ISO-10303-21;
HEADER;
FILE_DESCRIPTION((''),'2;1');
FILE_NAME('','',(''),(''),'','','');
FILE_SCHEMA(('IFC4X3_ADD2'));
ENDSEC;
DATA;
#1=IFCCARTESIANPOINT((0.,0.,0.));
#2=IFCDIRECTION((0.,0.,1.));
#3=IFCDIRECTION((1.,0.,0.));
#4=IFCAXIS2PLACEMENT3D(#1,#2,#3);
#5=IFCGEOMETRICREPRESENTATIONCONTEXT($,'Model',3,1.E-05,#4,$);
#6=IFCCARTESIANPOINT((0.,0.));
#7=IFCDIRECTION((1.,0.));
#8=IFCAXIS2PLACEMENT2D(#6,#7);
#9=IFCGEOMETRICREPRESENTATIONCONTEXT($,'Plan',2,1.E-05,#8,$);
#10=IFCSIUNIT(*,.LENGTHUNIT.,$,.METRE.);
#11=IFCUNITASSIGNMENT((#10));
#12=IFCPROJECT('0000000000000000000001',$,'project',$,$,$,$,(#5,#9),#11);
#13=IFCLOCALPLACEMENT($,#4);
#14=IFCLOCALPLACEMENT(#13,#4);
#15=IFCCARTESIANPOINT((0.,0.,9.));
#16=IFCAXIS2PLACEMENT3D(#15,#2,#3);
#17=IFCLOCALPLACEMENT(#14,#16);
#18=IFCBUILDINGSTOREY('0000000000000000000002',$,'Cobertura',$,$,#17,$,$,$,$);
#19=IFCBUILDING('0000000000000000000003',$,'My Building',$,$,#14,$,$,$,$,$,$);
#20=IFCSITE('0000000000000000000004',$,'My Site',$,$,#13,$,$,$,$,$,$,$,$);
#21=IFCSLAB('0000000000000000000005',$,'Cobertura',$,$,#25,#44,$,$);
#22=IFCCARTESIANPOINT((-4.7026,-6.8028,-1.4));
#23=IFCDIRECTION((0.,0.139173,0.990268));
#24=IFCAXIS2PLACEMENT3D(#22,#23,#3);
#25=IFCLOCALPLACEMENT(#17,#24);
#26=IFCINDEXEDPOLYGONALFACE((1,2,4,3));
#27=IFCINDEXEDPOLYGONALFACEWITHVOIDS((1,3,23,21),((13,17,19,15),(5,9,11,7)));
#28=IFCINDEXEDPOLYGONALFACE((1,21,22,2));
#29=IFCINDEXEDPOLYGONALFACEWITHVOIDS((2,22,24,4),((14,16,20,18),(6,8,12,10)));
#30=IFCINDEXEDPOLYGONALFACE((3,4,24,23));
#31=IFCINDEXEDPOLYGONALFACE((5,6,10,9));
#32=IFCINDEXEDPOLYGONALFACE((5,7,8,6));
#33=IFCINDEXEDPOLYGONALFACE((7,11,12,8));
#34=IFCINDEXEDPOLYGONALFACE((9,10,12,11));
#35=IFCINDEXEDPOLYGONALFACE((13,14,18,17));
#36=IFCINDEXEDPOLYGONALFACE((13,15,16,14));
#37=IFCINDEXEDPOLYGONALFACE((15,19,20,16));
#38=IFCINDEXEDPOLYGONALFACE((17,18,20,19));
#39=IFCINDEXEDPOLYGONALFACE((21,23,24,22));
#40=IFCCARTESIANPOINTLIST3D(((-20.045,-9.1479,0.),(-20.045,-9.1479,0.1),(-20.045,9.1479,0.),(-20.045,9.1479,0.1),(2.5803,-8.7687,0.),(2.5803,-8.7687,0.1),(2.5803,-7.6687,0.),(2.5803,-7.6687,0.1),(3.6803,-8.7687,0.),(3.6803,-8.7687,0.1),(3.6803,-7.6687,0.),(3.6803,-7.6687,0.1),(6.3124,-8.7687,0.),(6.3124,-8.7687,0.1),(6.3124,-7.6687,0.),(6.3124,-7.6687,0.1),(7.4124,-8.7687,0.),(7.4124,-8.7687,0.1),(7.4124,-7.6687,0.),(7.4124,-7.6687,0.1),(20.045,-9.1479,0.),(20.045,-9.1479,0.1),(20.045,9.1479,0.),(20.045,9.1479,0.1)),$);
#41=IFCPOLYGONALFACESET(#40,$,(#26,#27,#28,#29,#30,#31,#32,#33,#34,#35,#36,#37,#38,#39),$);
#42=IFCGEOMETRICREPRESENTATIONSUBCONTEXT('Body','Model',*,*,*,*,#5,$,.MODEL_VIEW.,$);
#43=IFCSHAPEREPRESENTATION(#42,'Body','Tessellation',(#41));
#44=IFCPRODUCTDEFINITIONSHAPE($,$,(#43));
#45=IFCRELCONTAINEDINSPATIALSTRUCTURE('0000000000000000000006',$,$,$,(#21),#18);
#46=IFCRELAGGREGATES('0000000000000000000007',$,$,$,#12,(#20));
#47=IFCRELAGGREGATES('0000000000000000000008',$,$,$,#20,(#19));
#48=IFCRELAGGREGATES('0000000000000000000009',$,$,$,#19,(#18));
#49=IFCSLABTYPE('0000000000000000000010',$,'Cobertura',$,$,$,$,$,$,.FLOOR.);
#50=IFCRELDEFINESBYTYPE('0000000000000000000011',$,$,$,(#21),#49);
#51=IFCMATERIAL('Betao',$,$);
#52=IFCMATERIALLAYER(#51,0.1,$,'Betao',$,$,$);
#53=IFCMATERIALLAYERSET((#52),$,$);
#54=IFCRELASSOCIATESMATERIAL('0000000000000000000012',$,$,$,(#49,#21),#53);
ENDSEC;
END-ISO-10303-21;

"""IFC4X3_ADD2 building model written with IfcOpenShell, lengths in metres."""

from ifc_helpers import new_model, si_unit, frame, origin_with_axes, origin_2d_with_axis, place, context, subcontext, project, spatial, line, indexed_curve, outline, extrude, material, layer, layer_set, layer_usage, type_object, element, save


model = new_model("IFC4X3_ADD2")

# Units and contexts
model_context = context("Model", 3, precision=1e-05, world=origin_with_axes())
plan_context = context("Plan", 2, precision=1e-05, world=origin_2d_with_axis())
body_context = subcontext(model_context, "Body", "Model", "MODEL_VIEW")
ifc_project = project(units=[si_unit("LENGTHUNIT", "METRE")], contexts=[model_context, plan_context])

# Site, building, storey
site_placement = place(None, origin_with_axes())
site = spatial("IfcSite", under=ifc_project, at=site_placement, Name="My Site")
building_placement = place(site_placement, origin_with_axes())
building = spatial("IfcBuilding", under=site, at=building_placement, Name="My Building")
storey_placement = place(building_placement, frame((0.0, 0.0, 9.0), z_axis=(0.0, 0.0, 1.0), x_axis=(1.0, 0.0, 0.0)))
storey = spatial("IfcBuildingStorey", under=building, at=storey_placement, Name="Cobertura")

# Slab
ifc_material_1 = material(Name="Betao")
ifc_layer_1 = layer(ifc_material_1, 0.1, Name="Betao")
ifc_layer_set_1 = layer_set([ifc_layer_1])
ifc_layer_usage_1 = layer_usage(ifc_layer_set_1, "AXIS3", "POSITIVE", 0.0)
slab_type = type_object("IfcSlabType", Name="Cobertura", PredefinedType="FLOOR", material=ifc_layer_set_1)
slab_placement = place(storey_placement, frame((-4.7026, -6.8028, -1.4), z_axis=(0.0, 0.139173, 0.990268), x_axis=(1.0, 0.0, 0.0)))
element("IfcSlab", 1, at=slab_placement, inside=storey, type_object=slab_type, material=ifc_layer_usage_1, Name="Cobertura", context=body_context, shape_type="SweptSolid", body=[
    extrude(outline(indexed_curve([(-20.045, 9.1479), (20.045, 9.1479), (20.045, -9.1479), (-20.045, -9.1479)], segments=[line(1, 2, 3, 4, 1)]), holes=[indexed_curve([(7.4124, -8.7687), (7.4124, -7.6687), (6.3124, -7.6687), (6.3124, -8.7687)], segments=[line(1, 2, 3, 4, 1)]), indexed_curve([(2.5803, -8.7687), (2.5803, -7.6687), (3.6803, -7.6687), (3.6803, -8.7687)], segments=[line(1, 2, 3, 4, 1)])]), origin_with_axes(), (0.0, 0.0, 1.0), 0.1),
])

save(model, "model.ifc")
